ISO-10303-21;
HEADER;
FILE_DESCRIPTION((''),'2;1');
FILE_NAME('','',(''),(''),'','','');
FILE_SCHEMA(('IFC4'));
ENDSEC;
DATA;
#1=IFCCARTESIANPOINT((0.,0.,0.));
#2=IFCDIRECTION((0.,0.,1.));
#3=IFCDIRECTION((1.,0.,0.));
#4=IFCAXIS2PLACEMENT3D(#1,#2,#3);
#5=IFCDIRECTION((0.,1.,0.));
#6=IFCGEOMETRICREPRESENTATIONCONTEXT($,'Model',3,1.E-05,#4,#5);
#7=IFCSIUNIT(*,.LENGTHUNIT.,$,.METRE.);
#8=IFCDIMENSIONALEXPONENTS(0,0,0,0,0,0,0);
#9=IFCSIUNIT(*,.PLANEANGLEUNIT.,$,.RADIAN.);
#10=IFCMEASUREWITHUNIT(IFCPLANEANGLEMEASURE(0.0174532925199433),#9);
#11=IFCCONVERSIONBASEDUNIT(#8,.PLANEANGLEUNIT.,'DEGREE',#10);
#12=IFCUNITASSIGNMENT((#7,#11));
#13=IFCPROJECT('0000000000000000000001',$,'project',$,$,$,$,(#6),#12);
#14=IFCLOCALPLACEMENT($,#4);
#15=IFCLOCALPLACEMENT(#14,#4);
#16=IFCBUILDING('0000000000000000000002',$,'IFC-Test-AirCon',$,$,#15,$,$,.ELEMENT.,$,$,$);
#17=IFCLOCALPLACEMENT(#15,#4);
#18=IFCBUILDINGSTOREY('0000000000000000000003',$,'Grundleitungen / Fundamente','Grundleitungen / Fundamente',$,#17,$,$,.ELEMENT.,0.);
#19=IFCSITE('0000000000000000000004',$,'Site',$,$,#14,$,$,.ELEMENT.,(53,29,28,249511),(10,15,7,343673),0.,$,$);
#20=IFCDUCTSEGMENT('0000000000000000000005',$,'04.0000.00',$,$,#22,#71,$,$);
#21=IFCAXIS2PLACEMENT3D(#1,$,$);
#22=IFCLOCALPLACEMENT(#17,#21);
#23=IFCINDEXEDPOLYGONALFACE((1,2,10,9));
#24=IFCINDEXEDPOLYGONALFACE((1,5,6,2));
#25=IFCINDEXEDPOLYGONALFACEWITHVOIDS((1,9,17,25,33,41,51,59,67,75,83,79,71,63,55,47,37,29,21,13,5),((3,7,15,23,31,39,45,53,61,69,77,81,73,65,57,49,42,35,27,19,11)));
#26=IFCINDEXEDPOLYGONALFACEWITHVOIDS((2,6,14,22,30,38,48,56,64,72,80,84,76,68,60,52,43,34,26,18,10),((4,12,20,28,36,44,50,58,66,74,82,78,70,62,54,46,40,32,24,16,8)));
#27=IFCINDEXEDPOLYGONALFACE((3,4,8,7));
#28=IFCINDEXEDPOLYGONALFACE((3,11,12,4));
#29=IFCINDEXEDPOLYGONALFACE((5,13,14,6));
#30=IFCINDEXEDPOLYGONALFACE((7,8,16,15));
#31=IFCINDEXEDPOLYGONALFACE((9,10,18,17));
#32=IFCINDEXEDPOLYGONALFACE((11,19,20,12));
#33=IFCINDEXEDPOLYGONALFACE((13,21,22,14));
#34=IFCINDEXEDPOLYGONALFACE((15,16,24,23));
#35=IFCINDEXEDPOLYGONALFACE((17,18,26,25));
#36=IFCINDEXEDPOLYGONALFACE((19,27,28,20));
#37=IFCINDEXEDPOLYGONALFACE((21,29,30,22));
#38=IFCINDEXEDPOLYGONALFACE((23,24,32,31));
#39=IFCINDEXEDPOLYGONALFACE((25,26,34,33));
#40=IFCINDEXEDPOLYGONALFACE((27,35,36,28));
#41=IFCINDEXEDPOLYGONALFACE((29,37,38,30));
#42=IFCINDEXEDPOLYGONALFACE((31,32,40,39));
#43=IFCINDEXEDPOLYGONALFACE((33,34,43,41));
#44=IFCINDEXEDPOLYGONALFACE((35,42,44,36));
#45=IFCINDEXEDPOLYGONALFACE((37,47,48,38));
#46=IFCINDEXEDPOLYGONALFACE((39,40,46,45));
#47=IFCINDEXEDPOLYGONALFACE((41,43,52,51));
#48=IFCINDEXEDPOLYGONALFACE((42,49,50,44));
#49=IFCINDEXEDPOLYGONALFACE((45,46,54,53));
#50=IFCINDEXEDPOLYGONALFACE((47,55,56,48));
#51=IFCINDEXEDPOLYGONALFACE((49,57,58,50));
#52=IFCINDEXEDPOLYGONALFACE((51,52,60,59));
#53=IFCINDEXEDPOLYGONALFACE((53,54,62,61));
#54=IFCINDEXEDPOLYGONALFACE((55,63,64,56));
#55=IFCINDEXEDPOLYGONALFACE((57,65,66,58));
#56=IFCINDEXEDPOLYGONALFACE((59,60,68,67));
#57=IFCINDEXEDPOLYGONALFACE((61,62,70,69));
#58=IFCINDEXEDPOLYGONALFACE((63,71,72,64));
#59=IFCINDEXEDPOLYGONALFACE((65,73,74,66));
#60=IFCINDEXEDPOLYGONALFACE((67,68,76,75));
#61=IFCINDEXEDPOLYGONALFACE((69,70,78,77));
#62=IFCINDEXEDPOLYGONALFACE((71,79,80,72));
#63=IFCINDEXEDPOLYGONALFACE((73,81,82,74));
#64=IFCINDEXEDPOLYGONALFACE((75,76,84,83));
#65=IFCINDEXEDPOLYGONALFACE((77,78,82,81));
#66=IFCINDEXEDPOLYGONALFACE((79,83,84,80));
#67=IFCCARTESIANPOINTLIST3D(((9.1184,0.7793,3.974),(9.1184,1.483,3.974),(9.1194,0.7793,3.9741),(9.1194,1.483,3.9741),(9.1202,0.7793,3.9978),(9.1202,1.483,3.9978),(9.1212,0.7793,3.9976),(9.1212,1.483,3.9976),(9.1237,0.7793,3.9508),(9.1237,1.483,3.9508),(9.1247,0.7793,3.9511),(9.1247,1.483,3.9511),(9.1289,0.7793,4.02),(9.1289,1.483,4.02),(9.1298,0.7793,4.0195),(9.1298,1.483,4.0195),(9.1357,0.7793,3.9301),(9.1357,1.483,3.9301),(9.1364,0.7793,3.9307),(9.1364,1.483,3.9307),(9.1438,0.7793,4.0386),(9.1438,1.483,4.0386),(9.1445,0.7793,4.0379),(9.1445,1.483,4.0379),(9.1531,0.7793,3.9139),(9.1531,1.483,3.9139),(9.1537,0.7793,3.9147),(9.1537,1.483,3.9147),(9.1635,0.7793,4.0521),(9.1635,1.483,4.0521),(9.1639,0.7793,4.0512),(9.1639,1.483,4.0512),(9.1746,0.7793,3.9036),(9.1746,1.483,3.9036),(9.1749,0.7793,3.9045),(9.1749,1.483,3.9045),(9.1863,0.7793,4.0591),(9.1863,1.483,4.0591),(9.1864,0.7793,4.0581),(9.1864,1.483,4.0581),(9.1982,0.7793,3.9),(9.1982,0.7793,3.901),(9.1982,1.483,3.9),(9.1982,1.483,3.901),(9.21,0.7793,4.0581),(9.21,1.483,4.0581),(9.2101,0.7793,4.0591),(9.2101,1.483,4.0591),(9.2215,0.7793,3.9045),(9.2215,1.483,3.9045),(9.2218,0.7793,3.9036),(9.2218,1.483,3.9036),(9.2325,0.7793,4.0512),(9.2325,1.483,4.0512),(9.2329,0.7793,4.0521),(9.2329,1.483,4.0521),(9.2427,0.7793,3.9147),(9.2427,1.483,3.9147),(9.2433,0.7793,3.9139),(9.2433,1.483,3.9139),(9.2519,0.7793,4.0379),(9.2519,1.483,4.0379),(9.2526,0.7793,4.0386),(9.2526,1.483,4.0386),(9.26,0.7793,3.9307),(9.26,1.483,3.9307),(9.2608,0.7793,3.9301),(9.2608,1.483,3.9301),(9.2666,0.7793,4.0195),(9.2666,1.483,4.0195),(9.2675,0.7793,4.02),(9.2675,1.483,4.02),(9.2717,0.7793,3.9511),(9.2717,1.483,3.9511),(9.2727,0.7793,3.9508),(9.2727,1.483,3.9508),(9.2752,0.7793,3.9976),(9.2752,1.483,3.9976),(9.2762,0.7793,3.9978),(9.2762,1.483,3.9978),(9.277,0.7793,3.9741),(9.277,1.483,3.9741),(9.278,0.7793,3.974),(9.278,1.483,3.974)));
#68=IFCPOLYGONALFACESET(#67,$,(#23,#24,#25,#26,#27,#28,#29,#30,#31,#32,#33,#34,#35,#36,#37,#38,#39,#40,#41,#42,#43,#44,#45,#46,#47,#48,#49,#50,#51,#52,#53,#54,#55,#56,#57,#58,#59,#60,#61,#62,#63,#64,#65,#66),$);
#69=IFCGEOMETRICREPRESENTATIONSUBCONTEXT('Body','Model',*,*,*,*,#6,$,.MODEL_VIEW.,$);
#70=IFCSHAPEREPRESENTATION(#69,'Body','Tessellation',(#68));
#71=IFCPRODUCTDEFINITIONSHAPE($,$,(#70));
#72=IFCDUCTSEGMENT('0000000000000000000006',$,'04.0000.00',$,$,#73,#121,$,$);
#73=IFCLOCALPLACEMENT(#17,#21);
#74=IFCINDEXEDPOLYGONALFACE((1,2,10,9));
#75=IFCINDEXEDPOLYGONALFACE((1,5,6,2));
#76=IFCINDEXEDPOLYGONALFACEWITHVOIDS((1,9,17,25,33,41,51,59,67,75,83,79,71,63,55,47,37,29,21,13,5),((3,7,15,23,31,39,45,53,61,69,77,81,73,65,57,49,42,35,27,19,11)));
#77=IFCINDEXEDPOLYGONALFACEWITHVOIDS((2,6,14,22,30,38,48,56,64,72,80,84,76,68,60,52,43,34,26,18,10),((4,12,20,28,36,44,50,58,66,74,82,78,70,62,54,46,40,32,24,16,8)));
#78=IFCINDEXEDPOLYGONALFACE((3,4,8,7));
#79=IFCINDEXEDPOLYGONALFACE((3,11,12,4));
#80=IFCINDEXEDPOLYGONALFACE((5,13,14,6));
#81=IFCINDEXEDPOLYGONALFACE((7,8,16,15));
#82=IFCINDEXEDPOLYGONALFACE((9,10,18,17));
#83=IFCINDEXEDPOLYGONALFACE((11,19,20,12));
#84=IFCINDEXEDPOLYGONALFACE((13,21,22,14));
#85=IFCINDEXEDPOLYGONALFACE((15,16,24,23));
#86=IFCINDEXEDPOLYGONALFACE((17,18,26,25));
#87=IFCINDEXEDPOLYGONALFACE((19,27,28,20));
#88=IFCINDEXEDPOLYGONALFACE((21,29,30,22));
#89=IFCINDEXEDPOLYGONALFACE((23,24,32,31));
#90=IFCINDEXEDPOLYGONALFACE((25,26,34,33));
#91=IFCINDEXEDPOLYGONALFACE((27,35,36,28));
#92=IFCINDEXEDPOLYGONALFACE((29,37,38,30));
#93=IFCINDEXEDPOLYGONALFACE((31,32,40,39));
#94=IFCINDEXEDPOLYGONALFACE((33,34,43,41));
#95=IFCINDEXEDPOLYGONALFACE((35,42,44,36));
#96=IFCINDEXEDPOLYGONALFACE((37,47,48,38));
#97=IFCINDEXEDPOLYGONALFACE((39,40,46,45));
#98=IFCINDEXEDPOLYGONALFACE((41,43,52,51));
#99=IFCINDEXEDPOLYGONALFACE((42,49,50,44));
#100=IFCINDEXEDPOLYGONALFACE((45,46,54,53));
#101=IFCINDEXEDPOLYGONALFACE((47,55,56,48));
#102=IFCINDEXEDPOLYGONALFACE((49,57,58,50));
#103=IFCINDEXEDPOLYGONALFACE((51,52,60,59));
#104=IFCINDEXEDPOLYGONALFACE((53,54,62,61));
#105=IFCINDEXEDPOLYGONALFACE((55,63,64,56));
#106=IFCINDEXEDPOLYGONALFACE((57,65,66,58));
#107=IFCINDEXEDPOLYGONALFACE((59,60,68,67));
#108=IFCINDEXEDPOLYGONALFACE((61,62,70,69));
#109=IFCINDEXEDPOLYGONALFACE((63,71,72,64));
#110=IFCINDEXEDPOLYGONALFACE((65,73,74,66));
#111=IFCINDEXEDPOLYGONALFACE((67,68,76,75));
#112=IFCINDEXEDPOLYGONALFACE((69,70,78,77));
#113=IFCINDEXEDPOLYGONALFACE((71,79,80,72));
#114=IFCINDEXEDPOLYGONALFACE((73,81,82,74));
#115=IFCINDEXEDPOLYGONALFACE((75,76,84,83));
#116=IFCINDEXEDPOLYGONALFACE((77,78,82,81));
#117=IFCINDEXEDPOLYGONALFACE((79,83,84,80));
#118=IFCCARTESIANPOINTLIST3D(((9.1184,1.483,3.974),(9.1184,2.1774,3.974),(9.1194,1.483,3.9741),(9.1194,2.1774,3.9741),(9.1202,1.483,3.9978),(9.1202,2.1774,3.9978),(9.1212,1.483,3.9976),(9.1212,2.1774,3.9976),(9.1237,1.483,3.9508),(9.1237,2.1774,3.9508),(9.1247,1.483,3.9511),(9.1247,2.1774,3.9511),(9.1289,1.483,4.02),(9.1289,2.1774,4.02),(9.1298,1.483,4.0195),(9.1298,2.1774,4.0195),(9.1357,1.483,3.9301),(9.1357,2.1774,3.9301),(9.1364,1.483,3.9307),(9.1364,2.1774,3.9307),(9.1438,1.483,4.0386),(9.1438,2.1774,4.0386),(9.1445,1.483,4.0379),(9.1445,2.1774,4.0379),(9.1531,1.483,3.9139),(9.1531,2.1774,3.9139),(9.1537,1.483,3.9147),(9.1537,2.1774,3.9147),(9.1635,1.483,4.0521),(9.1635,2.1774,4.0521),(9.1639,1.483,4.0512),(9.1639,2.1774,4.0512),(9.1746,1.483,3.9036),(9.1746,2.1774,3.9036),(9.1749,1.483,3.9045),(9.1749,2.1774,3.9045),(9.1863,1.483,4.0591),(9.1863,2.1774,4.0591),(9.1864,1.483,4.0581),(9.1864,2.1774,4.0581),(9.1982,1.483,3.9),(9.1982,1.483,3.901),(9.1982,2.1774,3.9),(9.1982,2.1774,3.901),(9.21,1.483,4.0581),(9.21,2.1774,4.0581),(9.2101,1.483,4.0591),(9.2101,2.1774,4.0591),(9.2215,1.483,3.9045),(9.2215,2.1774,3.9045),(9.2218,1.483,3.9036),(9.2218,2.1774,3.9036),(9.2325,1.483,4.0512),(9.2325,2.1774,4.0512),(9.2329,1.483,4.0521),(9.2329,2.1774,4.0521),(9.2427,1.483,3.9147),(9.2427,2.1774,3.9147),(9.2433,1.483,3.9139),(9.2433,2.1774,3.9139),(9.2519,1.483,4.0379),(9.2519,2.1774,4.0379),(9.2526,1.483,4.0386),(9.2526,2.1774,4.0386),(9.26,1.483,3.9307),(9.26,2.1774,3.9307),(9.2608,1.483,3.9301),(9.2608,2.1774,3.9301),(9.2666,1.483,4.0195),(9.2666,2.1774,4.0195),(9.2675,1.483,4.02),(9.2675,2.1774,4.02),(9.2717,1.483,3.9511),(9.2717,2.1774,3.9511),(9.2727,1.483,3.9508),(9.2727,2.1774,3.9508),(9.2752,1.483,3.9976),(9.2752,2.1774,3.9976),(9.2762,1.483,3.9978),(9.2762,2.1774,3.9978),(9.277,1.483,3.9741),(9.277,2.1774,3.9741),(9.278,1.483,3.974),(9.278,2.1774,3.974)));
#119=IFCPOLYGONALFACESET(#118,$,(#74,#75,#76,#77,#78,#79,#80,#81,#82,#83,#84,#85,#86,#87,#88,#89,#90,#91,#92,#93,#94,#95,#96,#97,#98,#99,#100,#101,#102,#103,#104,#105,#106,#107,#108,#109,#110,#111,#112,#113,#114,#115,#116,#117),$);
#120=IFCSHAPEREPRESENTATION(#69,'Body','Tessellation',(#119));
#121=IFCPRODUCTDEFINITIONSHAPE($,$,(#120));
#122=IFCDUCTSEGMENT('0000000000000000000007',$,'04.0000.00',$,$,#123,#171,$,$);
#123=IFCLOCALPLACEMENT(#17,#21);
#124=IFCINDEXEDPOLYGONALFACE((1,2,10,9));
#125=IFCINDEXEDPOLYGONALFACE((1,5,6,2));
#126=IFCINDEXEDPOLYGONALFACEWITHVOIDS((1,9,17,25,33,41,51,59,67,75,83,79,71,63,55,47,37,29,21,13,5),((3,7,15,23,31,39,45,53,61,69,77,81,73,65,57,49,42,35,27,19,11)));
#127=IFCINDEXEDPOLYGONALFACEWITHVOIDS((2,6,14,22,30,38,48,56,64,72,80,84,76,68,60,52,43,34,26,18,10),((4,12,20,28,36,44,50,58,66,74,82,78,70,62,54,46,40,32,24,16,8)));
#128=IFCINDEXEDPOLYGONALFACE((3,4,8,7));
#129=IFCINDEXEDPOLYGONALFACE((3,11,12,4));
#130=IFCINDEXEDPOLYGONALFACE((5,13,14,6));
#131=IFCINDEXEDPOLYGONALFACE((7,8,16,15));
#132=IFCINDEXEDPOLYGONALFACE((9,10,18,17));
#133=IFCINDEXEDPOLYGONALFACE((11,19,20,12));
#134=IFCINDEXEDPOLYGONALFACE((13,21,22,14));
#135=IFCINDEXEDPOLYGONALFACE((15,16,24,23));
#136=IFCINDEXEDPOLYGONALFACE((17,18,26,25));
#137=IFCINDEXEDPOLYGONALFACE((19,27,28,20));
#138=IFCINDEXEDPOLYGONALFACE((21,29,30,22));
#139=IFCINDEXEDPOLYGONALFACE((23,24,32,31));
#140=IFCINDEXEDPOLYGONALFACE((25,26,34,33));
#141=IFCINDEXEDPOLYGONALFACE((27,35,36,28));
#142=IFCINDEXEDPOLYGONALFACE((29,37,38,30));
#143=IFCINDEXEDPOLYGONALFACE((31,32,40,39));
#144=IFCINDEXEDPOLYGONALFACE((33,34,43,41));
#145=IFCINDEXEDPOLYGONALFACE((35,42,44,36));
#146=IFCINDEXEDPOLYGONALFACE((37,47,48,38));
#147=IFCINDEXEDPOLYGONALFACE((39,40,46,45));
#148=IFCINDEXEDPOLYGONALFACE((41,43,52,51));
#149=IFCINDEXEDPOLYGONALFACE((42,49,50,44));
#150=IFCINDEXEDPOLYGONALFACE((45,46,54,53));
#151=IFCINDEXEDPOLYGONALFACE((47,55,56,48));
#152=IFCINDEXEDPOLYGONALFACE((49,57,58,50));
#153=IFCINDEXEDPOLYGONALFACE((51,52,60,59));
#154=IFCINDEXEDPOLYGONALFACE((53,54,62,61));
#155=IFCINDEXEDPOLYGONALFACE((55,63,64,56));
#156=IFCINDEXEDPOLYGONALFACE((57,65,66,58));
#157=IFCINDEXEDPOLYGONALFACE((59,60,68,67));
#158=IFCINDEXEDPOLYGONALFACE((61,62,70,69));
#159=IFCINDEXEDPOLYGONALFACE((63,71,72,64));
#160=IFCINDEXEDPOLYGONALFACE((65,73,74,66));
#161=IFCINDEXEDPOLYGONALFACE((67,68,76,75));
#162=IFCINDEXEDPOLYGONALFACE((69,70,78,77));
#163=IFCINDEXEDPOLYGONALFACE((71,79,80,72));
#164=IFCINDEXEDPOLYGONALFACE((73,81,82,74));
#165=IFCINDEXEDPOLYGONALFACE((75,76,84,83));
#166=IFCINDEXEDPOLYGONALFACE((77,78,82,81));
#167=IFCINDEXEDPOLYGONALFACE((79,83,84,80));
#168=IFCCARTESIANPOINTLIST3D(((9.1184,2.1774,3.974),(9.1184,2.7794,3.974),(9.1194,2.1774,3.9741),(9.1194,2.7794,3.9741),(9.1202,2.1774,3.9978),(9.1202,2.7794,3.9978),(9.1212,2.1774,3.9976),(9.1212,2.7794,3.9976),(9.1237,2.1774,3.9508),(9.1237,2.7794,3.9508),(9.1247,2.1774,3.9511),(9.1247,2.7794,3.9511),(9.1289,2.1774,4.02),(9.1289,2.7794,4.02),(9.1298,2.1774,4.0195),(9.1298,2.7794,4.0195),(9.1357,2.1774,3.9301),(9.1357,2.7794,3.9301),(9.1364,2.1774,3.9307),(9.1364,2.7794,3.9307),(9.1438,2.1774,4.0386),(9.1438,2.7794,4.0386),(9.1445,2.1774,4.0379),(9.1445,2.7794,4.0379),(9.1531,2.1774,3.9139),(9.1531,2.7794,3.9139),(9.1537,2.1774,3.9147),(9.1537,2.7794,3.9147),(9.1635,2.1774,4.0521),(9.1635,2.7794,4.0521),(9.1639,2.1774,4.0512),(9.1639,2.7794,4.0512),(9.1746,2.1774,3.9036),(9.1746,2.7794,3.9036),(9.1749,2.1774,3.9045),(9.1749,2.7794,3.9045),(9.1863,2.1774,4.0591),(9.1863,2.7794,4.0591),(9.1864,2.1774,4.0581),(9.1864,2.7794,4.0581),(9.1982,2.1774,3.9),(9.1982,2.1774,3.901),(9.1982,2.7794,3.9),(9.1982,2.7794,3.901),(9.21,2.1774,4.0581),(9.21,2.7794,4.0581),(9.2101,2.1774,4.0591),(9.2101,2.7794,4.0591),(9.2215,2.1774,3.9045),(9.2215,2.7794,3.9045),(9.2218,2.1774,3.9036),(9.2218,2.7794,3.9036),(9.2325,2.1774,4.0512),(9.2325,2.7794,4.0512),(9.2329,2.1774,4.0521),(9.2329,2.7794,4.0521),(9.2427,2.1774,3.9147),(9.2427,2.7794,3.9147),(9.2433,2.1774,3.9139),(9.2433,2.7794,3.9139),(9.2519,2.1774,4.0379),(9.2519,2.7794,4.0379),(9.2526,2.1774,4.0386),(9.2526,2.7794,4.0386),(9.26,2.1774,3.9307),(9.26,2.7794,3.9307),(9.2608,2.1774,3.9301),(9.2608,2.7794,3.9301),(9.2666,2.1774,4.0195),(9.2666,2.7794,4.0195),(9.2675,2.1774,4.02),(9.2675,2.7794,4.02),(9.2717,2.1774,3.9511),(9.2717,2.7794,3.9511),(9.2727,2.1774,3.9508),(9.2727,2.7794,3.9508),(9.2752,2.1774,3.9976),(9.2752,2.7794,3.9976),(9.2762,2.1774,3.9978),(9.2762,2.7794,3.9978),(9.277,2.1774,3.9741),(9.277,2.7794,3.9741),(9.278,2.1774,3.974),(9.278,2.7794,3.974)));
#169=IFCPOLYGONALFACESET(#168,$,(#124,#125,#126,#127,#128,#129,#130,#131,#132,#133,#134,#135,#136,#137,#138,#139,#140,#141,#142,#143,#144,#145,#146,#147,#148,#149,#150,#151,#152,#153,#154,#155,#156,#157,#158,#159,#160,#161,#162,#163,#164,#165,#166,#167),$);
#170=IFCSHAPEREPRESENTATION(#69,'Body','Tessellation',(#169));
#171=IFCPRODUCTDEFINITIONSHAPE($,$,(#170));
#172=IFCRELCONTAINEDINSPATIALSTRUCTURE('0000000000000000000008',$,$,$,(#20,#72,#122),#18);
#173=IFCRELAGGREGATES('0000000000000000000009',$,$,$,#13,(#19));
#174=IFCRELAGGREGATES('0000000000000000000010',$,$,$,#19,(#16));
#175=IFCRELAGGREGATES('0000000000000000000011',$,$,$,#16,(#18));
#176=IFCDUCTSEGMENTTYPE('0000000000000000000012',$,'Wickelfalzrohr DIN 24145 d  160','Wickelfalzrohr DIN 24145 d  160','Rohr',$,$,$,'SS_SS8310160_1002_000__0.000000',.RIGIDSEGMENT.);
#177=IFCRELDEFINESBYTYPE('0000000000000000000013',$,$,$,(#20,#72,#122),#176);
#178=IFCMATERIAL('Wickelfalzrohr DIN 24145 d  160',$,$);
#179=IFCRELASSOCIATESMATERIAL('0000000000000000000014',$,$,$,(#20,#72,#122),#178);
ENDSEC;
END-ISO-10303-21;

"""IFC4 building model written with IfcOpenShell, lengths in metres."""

from ifc_helpers import new_model, entity, si_unit, converted_unit, direction, frame, origin_with_axes, origin_2d_with_axis, place, context, subcontext, project, spatial, hollow_circle, extrude, material, type_object, element, save


model = new_model("IFC4")

# Units and contexts
model_context = context("Model", 3, precision=1e-05, world=origin_with_axes(), true_north=direction((0.0, 1.0, 0.0)))
body_context = subcontext(model_context, "Body", "Model", "MODEL_VIEW")
ifc_project = project(units=[si_unit("LENGTHUNIT", "METRE"), converted_unit("PLANEANGLEUNIT", "DEGREE", entity("IfcPlaneAngleMeasure", 0.0174532925199433), si_unit("PLANEANGLEUNIT", "RADIAN"), dimensions=[0, 0, 0, 0, 0, 0, 0])], contexts=[model_context])

# Site, building, storey
site_placement = place(None, origin_with_axes())
site = spatial("IfcSite", under=ifc_project, at=site_placement, Name="Site", CompositionType="ELEMENT", RefLatitude=(53, 29, 28, 249511), RefLongitude=(10, 15, 7, 343673), RefElevation=0.0)
building_placement = place(site_placement, origin_with_axes())
building = spatial("IfcBuilding", under=site, at=building_placement, Name="IFC-Test-AirCon", CompositionType="ELEMENT")
storey_placement = place(building_placement, origin_with_axes())
storey = spatial("IfcBuildingStorey", under=building, at=storey_placement, Name="Grundleitungen / Fundamente", Description="Grundleitungen / Fundamente", CompositionType="ELEMENT", Elevation=0.0)

# Duct segments
ifc_material_1 = material(Name="Wickelfalzrohr DIN 24145 d  160")
duct_segment_type_1 = type_object("IfcDuctSegmentType", Name="Wickelfalzrohr DIN 24145 d  160", Description="Wickelfalzrohr DIN 24145 d  160", ApplicableOccurrence="Rohr", ElementType="SS_SS8310160_1002_000__0.000000", PredefinedType="RIGIDSEGMENT")
duct_segment_1_placement = place(storey_placement, frame((9.1982, 0.7793, 3.98), z_axis=(0.0, 0.0, 1.0), x_axis=(0.0, 1.0, 0.0)))
element("IfcDuctSegment", 1, at=duct_segment_1_placement, inside=storey, type_object=duct_segment_type_1, material=ifc_material_1, Name="04.0000.00", context=body_context, shape_type="SweptSolid", body=[
    extrude(hollow_circle(Radius=0.08, WallThickness=0.001, at=origin_2d_with_axis()), frame((0.0, 0.0, 0.0), z_axis=(1.0, 0.0, 0.0), x_axis=(0.0, 0.0, -1.0)), (0.0, 0.0, 1.0), 0.7037),
])
duct_segment_2_placement = place(storey_placement, frame((9.1982, 1.483, 3.98), z_axis=(0.0, 0.0, 1.0), x_axis=(0.0, 1.0, 0.0)))
element("IfcDuctSegment", 2, at=duct_segment_2_placement, inside=storey, type_object=duct_segment_type_1, material=ifc_material_1, Name="04.0000.00", context=body_context, shape_type="SweptSolid", body=[
    extrude(hollow_circle(Radius=0.08, WallThickness=0.001, at=origin_2d_with_axis()), frame((0.0, 0.0, 0.0), z_axis=(1.0, 0.0, 0.0), x_axis=(0.0, 0.0, -1.0)), (0.0, 0.0, 1.0), 0.6944),
])
duct_segment_3_placement = place(storey_placement, frame((9.1982, 2.1774, 3.98), z_axis=(0.0, 0.0, 1.0), x_axis=(0.0, 1.0, 0.0)))
element("IfcDuctSegment", 3, at=duct_segment_3_placement, inside=storey, type_object=duct_segment_type_1, material=ifc_material_1, Name="04.0000.00", context=body_context, shape_type="SweptSolid", body=[
    extrude(hollow_circle(Radius=0.08, WallThickness=0.001, at=origin_2d_with_axis()), frame((0.0, 0.0, 0.0), z_axis=(1.0, 0.0, 0.0), x_axis=(0.0, 0.0, -1.0)), (0.0, 0.0, 1.0), 0.602),
])

save(model, "model.ifc")
